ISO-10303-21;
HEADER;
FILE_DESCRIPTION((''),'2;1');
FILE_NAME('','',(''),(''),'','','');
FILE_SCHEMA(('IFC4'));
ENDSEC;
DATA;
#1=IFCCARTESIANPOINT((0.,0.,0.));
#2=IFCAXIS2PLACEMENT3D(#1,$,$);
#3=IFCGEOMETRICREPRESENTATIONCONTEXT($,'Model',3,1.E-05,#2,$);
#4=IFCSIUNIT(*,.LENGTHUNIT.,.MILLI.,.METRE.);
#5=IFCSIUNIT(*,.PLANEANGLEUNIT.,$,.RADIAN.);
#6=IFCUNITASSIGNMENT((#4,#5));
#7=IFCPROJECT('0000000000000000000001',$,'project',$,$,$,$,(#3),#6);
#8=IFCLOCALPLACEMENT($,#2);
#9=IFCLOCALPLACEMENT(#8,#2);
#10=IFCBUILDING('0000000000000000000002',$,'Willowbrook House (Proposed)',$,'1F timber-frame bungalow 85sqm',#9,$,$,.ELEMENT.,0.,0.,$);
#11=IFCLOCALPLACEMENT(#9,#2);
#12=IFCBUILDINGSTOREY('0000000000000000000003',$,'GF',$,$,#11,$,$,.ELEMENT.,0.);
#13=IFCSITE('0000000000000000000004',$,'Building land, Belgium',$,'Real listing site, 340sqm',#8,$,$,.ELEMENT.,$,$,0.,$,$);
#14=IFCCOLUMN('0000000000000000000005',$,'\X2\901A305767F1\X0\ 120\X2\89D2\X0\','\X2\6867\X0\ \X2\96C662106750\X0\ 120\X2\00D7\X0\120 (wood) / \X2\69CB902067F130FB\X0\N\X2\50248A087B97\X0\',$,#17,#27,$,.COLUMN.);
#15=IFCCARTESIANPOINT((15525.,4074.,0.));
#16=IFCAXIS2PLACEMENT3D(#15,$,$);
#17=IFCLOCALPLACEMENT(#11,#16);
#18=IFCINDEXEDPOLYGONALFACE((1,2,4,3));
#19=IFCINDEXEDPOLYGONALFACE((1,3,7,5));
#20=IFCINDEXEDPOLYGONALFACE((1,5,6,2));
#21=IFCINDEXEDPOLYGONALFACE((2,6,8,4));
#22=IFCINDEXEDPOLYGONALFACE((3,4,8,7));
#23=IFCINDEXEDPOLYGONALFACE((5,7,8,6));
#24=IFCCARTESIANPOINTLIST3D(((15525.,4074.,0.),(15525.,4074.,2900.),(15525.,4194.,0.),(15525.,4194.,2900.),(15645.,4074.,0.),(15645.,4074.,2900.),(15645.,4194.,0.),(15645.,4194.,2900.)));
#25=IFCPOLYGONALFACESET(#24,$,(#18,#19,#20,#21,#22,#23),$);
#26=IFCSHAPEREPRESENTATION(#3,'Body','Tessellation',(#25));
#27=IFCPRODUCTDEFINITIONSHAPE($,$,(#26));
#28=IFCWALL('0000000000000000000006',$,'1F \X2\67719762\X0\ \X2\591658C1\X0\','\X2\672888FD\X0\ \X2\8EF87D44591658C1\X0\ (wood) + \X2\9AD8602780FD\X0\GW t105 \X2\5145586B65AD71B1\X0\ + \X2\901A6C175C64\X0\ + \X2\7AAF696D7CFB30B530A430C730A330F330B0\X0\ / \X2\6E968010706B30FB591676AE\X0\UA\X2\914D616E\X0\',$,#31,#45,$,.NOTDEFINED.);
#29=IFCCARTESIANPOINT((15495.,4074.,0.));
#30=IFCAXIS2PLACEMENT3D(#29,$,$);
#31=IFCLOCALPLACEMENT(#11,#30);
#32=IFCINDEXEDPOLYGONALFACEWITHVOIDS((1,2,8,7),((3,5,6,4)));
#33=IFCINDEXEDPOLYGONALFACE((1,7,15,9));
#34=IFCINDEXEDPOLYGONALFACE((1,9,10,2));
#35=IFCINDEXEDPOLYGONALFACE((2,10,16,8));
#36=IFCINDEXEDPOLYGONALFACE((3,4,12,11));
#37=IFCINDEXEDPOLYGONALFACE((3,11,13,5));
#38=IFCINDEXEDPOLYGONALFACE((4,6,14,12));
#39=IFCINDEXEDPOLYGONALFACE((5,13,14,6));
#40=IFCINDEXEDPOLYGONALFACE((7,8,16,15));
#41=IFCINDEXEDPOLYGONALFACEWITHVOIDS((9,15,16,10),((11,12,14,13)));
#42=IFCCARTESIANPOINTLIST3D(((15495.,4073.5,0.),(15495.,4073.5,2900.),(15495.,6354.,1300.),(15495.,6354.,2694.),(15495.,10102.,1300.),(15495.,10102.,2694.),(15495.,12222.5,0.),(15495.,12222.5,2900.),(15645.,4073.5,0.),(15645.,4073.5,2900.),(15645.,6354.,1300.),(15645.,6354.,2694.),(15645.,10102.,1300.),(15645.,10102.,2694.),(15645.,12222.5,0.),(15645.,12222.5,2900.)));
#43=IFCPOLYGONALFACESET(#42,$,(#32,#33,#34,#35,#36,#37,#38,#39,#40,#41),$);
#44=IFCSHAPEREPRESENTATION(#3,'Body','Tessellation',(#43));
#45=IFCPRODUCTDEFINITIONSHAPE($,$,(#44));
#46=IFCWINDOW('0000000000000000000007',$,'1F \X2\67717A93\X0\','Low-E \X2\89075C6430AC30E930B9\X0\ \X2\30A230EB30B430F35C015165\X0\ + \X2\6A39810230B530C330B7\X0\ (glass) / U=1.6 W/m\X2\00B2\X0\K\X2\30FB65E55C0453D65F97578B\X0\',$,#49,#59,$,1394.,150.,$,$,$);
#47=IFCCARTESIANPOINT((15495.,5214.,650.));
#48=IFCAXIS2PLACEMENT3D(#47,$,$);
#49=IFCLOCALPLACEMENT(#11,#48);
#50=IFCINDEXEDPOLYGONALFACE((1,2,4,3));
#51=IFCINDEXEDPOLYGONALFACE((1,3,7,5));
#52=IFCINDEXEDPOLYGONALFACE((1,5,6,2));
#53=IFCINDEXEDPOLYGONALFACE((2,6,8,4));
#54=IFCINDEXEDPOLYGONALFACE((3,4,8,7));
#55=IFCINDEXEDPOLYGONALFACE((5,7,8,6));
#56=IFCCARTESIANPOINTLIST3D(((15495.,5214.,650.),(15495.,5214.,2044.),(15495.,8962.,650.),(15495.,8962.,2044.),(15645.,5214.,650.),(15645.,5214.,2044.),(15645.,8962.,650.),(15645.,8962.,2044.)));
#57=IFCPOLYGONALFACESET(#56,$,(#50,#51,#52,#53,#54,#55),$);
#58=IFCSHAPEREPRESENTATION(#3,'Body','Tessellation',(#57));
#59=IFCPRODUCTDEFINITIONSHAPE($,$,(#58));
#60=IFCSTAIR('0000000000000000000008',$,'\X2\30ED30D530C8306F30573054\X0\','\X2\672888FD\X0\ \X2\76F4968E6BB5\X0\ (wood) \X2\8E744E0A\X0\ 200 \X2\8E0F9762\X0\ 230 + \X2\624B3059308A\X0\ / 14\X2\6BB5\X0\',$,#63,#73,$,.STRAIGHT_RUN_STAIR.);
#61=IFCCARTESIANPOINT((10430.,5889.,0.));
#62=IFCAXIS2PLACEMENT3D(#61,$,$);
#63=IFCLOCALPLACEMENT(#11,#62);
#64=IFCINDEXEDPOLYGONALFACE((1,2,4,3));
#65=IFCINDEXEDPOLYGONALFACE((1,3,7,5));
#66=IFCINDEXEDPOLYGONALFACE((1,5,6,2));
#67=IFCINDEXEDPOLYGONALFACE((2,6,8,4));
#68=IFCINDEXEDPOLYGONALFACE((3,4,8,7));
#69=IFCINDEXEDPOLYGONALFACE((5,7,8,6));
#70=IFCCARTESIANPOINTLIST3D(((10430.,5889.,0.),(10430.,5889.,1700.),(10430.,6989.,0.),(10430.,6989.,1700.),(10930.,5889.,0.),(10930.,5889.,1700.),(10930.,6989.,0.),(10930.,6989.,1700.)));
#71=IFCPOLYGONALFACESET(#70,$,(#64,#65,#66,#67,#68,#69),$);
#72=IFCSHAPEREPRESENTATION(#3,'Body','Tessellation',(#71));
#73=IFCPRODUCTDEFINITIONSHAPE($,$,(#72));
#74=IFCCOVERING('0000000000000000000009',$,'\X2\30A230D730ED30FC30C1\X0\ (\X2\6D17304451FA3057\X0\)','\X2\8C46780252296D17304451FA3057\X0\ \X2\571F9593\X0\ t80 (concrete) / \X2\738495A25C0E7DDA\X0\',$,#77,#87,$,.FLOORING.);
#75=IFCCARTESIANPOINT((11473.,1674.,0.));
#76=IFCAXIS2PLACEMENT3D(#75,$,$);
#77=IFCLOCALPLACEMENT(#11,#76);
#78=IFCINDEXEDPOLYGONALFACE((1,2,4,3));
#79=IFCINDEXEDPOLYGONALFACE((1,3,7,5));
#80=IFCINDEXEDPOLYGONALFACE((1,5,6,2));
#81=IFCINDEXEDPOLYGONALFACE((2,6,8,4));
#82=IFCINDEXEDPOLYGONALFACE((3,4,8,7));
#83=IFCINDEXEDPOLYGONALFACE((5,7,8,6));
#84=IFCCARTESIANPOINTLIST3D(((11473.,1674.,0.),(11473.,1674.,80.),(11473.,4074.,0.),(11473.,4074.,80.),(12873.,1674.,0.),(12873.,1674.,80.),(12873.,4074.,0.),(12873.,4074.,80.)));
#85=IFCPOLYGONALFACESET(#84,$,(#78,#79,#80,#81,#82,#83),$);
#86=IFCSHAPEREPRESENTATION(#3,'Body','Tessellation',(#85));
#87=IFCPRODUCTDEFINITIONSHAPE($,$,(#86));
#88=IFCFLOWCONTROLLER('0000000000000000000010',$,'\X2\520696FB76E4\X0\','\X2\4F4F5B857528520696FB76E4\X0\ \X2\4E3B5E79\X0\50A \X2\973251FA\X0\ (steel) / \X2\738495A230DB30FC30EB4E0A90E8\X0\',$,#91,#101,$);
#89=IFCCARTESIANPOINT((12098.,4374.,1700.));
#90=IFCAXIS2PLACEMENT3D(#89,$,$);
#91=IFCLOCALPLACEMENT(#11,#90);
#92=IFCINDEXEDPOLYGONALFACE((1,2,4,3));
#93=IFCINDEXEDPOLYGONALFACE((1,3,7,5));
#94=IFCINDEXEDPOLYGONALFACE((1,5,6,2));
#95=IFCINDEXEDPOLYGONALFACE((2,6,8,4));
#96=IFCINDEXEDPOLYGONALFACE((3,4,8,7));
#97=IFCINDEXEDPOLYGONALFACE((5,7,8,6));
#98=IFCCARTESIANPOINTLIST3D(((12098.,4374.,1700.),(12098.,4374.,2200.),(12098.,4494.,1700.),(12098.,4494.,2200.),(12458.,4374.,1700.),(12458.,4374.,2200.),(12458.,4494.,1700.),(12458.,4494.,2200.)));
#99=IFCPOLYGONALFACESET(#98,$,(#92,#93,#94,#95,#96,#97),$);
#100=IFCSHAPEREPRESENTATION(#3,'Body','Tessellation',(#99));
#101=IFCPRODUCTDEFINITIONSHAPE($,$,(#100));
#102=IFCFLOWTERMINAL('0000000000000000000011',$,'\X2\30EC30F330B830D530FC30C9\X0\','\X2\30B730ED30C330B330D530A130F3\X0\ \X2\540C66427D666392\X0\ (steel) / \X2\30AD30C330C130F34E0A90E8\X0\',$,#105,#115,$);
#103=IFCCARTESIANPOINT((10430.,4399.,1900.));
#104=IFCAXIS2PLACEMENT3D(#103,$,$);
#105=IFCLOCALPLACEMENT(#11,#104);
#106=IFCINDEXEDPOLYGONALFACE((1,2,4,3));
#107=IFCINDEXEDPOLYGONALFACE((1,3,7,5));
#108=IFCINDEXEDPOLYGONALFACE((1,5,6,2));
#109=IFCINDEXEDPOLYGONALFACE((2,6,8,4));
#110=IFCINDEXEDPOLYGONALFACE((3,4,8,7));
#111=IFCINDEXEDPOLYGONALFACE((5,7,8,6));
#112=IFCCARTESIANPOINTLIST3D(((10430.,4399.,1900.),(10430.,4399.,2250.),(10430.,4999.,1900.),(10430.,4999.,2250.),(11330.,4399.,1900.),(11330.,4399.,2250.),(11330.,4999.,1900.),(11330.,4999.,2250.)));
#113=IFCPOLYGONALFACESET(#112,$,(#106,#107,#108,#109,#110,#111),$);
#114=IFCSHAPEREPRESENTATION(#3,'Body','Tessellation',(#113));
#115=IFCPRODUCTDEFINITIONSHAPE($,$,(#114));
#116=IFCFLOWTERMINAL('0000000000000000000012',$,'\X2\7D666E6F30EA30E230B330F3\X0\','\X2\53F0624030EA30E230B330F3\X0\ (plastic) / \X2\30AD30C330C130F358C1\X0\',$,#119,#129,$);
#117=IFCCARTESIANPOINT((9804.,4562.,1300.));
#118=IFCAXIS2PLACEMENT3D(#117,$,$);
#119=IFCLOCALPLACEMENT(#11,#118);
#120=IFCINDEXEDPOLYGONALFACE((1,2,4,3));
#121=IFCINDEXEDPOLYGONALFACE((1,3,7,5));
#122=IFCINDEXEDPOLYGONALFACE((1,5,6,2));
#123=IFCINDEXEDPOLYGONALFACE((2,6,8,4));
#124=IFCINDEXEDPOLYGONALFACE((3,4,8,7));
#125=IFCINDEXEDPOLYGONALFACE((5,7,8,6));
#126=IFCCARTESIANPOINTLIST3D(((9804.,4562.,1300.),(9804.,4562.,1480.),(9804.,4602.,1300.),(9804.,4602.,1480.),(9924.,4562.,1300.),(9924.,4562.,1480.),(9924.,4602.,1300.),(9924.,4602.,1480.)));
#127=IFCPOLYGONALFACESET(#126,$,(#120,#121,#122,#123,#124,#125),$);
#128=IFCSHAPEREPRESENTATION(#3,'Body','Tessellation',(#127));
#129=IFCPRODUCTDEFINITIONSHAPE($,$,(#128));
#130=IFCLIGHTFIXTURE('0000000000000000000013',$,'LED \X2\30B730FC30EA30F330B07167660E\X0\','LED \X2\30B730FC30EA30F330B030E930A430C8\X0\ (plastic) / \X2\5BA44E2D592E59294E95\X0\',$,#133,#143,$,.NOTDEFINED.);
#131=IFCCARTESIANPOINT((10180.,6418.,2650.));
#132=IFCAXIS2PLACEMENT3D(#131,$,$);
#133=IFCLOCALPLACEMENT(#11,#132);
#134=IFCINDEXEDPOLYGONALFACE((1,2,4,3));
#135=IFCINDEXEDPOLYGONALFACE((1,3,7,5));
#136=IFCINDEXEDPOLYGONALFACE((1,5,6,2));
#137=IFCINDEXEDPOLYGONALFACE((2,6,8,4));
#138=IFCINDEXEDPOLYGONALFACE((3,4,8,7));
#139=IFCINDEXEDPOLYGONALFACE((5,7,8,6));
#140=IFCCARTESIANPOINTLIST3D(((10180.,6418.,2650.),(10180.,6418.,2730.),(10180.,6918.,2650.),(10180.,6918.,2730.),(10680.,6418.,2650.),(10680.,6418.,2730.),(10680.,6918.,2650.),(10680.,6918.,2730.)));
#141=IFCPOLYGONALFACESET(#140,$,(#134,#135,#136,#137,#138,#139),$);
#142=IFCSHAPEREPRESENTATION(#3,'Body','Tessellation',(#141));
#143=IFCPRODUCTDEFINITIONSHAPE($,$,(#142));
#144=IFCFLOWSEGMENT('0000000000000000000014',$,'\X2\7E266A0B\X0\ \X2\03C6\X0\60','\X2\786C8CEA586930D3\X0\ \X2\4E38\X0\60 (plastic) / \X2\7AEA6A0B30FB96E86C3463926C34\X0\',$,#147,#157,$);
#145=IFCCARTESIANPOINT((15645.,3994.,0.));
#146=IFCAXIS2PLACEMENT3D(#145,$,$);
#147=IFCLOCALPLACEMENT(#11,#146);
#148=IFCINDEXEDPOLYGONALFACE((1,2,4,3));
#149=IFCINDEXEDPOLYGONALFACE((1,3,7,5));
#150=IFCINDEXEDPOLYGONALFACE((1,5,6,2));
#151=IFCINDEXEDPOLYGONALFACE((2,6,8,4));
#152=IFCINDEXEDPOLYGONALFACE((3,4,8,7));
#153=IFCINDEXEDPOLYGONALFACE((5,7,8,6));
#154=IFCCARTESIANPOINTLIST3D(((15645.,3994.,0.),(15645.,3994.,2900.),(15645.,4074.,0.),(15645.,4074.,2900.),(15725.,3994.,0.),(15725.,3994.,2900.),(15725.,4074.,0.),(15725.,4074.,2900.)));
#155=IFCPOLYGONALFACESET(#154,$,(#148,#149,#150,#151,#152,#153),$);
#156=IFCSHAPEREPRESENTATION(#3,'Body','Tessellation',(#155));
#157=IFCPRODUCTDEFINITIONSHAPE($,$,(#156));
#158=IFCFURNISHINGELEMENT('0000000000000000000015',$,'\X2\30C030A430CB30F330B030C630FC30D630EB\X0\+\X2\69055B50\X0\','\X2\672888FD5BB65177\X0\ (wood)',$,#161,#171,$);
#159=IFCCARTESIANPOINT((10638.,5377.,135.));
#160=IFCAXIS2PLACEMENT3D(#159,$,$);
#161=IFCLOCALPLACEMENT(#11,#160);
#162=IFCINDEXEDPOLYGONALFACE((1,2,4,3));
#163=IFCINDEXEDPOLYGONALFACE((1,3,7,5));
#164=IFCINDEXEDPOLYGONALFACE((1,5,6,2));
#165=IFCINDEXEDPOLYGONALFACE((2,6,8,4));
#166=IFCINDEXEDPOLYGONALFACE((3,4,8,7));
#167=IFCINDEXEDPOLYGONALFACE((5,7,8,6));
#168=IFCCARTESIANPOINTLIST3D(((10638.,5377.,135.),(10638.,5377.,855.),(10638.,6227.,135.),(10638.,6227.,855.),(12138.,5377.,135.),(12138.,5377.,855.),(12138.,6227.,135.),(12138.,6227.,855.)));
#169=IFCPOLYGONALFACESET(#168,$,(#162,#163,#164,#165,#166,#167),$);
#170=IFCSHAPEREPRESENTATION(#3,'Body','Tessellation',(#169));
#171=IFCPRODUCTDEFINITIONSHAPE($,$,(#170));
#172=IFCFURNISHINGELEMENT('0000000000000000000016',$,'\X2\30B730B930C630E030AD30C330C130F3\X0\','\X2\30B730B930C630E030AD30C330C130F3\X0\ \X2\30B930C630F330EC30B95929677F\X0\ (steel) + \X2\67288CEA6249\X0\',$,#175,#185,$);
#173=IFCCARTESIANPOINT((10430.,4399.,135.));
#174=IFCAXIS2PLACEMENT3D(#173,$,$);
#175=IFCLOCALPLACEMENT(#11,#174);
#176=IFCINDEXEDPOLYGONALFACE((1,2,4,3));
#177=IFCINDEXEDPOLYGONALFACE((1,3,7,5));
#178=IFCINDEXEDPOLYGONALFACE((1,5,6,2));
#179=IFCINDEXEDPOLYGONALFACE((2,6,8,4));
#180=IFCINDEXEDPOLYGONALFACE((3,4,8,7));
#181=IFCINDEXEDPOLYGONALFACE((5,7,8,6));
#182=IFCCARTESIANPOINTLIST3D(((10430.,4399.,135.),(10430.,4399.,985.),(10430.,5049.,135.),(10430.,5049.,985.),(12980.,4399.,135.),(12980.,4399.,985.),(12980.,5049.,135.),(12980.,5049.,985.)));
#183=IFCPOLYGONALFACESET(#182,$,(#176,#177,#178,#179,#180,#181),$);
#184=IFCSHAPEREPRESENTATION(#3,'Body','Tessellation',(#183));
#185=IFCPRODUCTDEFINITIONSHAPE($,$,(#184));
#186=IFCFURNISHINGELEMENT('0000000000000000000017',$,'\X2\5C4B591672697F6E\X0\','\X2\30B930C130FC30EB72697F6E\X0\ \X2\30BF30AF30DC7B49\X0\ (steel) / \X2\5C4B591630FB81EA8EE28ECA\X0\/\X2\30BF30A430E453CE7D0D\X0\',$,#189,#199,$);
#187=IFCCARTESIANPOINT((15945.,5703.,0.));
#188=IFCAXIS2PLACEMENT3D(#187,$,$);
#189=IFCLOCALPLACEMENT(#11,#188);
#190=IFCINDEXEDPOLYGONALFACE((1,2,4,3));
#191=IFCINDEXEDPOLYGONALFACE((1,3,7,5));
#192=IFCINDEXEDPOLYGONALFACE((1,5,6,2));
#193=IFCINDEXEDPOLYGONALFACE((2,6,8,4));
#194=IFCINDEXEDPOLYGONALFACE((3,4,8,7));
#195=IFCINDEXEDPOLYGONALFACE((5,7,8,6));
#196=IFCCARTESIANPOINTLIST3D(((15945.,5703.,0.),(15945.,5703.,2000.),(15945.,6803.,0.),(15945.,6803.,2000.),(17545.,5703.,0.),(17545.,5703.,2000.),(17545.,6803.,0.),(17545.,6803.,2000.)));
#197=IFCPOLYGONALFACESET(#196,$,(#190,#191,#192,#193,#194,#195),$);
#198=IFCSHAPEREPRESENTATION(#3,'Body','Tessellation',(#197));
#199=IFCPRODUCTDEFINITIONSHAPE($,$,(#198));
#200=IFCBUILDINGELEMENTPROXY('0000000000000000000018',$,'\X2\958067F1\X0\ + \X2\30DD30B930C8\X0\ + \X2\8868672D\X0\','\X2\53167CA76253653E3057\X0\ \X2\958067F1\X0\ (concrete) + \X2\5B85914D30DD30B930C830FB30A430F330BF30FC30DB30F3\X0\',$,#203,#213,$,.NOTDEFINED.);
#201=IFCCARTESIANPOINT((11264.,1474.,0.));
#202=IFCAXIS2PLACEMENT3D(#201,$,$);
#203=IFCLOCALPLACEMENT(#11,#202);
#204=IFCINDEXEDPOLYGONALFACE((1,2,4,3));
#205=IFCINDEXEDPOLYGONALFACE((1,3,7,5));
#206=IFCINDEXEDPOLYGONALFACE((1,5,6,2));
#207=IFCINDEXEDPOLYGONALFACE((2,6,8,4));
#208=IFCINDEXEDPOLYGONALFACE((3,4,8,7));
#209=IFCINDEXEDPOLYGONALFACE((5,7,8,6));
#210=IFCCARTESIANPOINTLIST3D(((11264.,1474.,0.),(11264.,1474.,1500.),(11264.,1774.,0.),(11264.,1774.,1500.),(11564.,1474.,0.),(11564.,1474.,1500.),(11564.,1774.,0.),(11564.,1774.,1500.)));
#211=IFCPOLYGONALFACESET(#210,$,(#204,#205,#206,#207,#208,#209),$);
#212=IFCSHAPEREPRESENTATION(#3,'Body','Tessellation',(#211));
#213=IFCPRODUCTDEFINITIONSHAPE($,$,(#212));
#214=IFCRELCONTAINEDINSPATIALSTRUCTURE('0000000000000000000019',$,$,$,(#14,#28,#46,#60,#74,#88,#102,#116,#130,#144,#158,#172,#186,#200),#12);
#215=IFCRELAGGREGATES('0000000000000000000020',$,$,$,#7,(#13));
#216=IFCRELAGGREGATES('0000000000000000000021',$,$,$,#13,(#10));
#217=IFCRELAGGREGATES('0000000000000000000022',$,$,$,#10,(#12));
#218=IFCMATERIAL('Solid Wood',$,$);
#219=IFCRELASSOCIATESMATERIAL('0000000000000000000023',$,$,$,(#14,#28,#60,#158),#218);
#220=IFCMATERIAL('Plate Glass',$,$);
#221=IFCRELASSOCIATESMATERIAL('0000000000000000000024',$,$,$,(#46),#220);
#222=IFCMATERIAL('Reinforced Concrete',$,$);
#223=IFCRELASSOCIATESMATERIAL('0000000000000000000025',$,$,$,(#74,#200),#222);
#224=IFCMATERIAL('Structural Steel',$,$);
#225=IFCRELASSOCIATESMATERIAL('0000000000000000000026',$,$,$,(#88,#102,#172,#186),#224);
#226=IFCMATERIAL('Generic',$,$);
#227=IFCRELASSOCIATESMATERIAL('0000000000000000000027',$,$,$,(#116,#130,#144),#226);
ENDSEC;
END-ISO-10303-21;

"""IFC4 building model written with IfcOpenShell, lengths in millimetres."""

from ifc_helpers import new_model, si_unit, frame, frame_2d, origin, place, context, project, spatial, rectangle, extrude, material, element, fill, save


model = new_model("IFC4")

# Units and contexts
model_context = context("Model", 3, precision=1e-05, world=origin())
ifc_project = project(units=[si_unit("LENGTHUNIT", "METRE", prefix="MILLI"), si_unit("PLANEANGLEUNIT", "RADIAN")], contexts=[model_context])

# Site, building, storey
site_placement = place(None, origin())
site = spatial("IfcSite", under=ifc_project, at=site_placement, Name="Building land, Belgium", ObjectType="Real listing site, 340sqm", CompositionType="ELEMENT", RefElevation=0.0)
building_placement = place(site_placement, origin())
building = spatial("IfcBuilding", under=site, at=building_placement, Name="Willowbrook House (Proposed)", ObjectType="1F timber-frame bungalow 85sqm", CompositionType="ELEMENT", ElevationOfRefHeight=0.0, ElevationOfTerrain=0.0)
storey_placement = place(building_placement, origin())
storey = spatial("IfcBuildingStorey", under=building, at=storey_placement, Name="GF", CompositionType="ELEMENT", Elevation=0.0)

# Column
ifc_material_1 = material(Name="Solid Wood")
column_1_placement = place(storey_placement, frame((15525.0, 4074.0, 0.0)))
element("IfcColumn", 1, at=column_1_placement, inside=storey, material=ifc_material_1, Name="通し柱 120角", Description="桧 集成材 120×120 (wood) / 構造柱・N値計算", PredefinedType="COLUMN", context=model_context, shape_type="SweptSolid", body=[
    extrude(rectangle(XDim=120.0, YDim=120.0, at=frame_2d((60.0, 60.0))), frame((15525.0, 4074.0, 0.0)), (0.0, 0.0, 1.0), 2900.0),
])

# Wall, opening, window
wall_1_placement = place(storey_placement, frame((15495.0, 4074.0, 0.0)))
wall_1 = element("IfcWall", 2, at=wall_1_placement, inside=storey, material=ifc_material_1, Name="1F 東面 外壁", Description="木製 軸組外壁 (wood) + 高性能GW t105 充填断熱 + 通気層 + 窯業系サイディング / 準耐火・外皮UA配慮", PredefinedType="NOTDEFINED", context=model_context, shape_type="SweptSolid", body=[
    extrude(rectangle(XDim=150.0, YDim=8149.0, at=frame_2d((75.0, 4074.0))), frame((15495.0, 4074.0, 0.0)), (0.0, 0.0, 1.0), 2900.0),
])
opening_placement = place(storey_placement, frame((15495.0, 5214.0, 650.0)))
opening = element("IfcOpeningElement", 3, at=opening_placement, cuts=wall_1, PredefinedType="NOTDEFINED", context=model_context, shape_type="SweptSolid", body=[
    extrude(rectangle(XDim=150.0, YDim=3748.0, at=frame_2d((75.0, 1874.0))), frame((15495.0, 5214.0, 650.0)), (0.0, 0.0, 1.0), 1394.0),
])
ifc_material_2 = material(Name="Plate Glass")
window_placement = place(storey_placement, frame((15495.0, 5214.0, 650.0)))
window = element("IfcWindow", 4, at=window_placement, inside=storey, material=ifc_material_2, Name="1F 東窓", Description="Low-E 複層ガラス アルゴン封入 + 樹脂サッシ (glass) / U=1.6 W/m²K・日射取得型", OverallHeight=1394.0, OverallWidth=150.0, context=model_context, shape_type="SweptSolid", body=[
    extrude(rectangle(XDim=150.0, YDim=3748.0, at=frame_2d((75.0, 1874.0))), frame((15495.0, 5214.0, 650.0)), (0.0, 0.0, 1.0), 1394.0),
])
fill(opening, window)

# Stair
stair_placement = place(storey_placement, frame((10430.0, 5889.0, 0.0)))
element("IfcStair", 5, at=stair_placement, inside=storey, material=ifc_material_1, Name="ロフトはしご", Description="木製 直階段 (wood) 蹴上 200 踏面 230 + 手すり / 14段", PredefinedType="STRAIGHT_RUN_STAIR", context=model_context, shape_type="SweptSolid", body=[
    extrude(rectangle(XDim=500.0, YDim=1100.0, at=frame_2d((250.0, 550.0))), frame((10430.0, 5889.0, 0.0)), (0.0, 0.0, 1.0), 1700.0),
])

# Covering
ifc_material_3 = material(Name="Reinforced Concrete")
covering_placement = place(storey_placement, frame((11473.0, 1674.0, 0.0)))
element("IfcCovering", 6, at=covering_placement, inside=storey, material=ifc_material_3, Name="アプローチ (洗い出し)", Description="豆砂利洗い出し 土間 t80 (concrete) / 玄関導線", PredefinedType="FLOORING", context=model_context, shape_type="SweptSolid", body=[
    extrude(rectangle(XDim=1400.0, YDim=2400.0, at=frame_2d((700.0, 1200.0))), frame((11473.0, 1674.0, 0.0)), (0.0, 0.0, 1.0), 80.0),
])

# Flow controller
ifc_material_4 = material(Name="Structural Steel")
flow_controller_placement = place(storey_placement, frame((12098.0, 4374.0, 1700.0)))
element("IfcFlowController", 7, at=flow_controller_placement, inside=storey, material=ifc_material_4, Name="分電盤", Description="住宅用分電盤 主幹50A 露出 (steel) / 玄関ホール上部", context=model_context, shape_type="SweptSolid", body=[
    extrude(rectangle(XDim=360.0, YDim=120.0, at=frame_2d((180.0, 60.0))), frame((12098.0, 4374.0, 1700.0)), (0.0, 0.0, 1.0), 500.0),
])

# Flow terminals
flow_terminal_1_placement = place(storey_placement, frame((10430.0, 4399.0, 1900.0)))
element("IfcFlowTerminal", 8, at=flow_terminal_1_placement, inside=storey, material=ifc_material_4, Name="レンジフード", Description="シロッコファン 同時給排 (steel) / キッチン上部", context=model_context, shape_type="SweptSolid", body=[
    extrude(rectangle(XDim=900.0, YDim=600.0, at=frame_2d((450.0, 300.0))), frame((10430.0, 4399.0, 1900.0)), (0.0, 0.0, 1.0), 350.0),
])
ifc_material_5 = material(Name="Generic")
flow_terminal_2_placement = place(storey_placement, frame((9804.0, 4562.0, 1300.0)))
element("IfcFlowTerminal", 9, at=flow_terminal_2_placement, inside=storey, material=ifc_material_5, Name="給湯リモコン", Description="台所リモコン (plastic) / キッチン壁", context=model_context, shape_type="SweptSolid", body=[
    extrude(rectangle(XDim=120.0, YDim=40.0, at=frame_2d((60.0, 20.0))), frame((9804.0, 4562.0, 1300.0)), (0.0, 0.0, 1.0), 180.0),
])

# Light fixture
light_fixture_placement = place(storey_placement, frame((10180.0, 6418.0, 2650.0)))
element("IfcLightFixture", 10, at=light_fixture_placement, inside=storey, material=ifc_material_5, Name="LED シーリング照明", Description="LED シーリングライト (plastic) / 室中央天井", PredefinedType="NOTDEFINED", context=model_context, shape_type="SweptSolid", body=[
    extrude(rectangle(XDim=500.0, YDim=500.0, at=frame_2d((250.0, 250.0))), frame((10180.0, 6418.0, 2650.0)), (0.0, 0.0, 1.0), 80.0),
])

# Flow segment
flow_segment_placement = place(storey_placement, frame((15645.0, 3994.0, 0.0)))
element("IfcFlowSegment", 11, at=flow_segment_placement, inside=storey, material=ifc_material_5, Name="縦樋 φ60", Description="硬質塩ビ 丸60 (plastic) / 竪樋・雨水排水", context=model_context, shape_type="SweptSolid", body=[
    extrude(rectangle(XDim=80.0, YDim=80.0, at=frame_2d((40.0, 40.0))), frame((15645.0, 3994.0, 0.0)), (0.0, 0.0, 1.0), 2900.0),
])

# Furnishing elements
furnishing_1_placement = place(storey_placement, frame((10638.0, 5377.0, 135.0)))
element("IfcFurnishingElement", 12, at=furnishing_1_placement, inside=storey, material=ifc_material_1, Name="ダイニングテーブル+椅子", Description="木製家具 (wood)", context=model_context, shape_type="SweptSolid", body=[
    extrude(rectangle(XDim=1500.0, YDim=850.0, at=frame_2d((750.0, 425.0))), frame((10638.0, 5377.0, 135.0)), (0.0, 0.0, 1.0), 720.0),
])
furnishing_2_placement = place(storey_placement, frame((10430.0, 4399.0, 135.0)))
element("IfcFurnishingElement", 13, at=furnishing_2_placement, inside=storey, material=ifc_material_4, Name="システムキッチン", Description="システムキッチン ステンレス天板 (steel) + 木質扉", context=model_context, shape_type="SweptSolid", body=[
    extrude(rectangle(XDim=2550.0, YDim=650.0, at=frame_2d((1275.0, 325.0))), frame((10430.0, 4399.0, 135.0)), (0.0, 0.0, 1.0), 850.0),
])
furnishing_3_placement = place(storey_placement, frame((15945.0, 5703.0, 0.0)))
element("IfcFurnishingElement", 14, at=furnishing_3_placement, inside=storey, material=ifc_material_4, Name="屋外物置", Description="スチール物置 タクボ等 (steel) / 屋外・自転車/タイヤ収納", context=model_context, shape_type="SweptSolid", body=[
    extrude(rectangle(XDim=1600.0, YDim=1100.0, at=frame_2d((800.0, 550.0))), frame((15945.0, 5703.0, 0.0)), (0.0, 0.0, 1.0), 2000.0),
])

# Building element proxy
proxy_placement = place(storey_placement, frame((11264.0, 1474.0, 0.0)))
element("IfcBuildingElementProxy", 15, at=proxy_placement, inside=storey, material=ifc_material_3, Name="門柱 + ポスト + 表札", Description="化粧打放し 門柱 (concrete) + 宅配ポスト・インターホン", PredefinedType="NOTDEFINED", context=model_context, shape_type="SweptSolid", body=[
    extrude(rectangle(XDim=300.0, YDim=300.0, at=frame_2d((150.0, 150.0))), frame((11264.0, 1474.0, 0.0)), (0.0, 0.0, 1.0), 1500.0),
])

save(model, "model.ifc")
